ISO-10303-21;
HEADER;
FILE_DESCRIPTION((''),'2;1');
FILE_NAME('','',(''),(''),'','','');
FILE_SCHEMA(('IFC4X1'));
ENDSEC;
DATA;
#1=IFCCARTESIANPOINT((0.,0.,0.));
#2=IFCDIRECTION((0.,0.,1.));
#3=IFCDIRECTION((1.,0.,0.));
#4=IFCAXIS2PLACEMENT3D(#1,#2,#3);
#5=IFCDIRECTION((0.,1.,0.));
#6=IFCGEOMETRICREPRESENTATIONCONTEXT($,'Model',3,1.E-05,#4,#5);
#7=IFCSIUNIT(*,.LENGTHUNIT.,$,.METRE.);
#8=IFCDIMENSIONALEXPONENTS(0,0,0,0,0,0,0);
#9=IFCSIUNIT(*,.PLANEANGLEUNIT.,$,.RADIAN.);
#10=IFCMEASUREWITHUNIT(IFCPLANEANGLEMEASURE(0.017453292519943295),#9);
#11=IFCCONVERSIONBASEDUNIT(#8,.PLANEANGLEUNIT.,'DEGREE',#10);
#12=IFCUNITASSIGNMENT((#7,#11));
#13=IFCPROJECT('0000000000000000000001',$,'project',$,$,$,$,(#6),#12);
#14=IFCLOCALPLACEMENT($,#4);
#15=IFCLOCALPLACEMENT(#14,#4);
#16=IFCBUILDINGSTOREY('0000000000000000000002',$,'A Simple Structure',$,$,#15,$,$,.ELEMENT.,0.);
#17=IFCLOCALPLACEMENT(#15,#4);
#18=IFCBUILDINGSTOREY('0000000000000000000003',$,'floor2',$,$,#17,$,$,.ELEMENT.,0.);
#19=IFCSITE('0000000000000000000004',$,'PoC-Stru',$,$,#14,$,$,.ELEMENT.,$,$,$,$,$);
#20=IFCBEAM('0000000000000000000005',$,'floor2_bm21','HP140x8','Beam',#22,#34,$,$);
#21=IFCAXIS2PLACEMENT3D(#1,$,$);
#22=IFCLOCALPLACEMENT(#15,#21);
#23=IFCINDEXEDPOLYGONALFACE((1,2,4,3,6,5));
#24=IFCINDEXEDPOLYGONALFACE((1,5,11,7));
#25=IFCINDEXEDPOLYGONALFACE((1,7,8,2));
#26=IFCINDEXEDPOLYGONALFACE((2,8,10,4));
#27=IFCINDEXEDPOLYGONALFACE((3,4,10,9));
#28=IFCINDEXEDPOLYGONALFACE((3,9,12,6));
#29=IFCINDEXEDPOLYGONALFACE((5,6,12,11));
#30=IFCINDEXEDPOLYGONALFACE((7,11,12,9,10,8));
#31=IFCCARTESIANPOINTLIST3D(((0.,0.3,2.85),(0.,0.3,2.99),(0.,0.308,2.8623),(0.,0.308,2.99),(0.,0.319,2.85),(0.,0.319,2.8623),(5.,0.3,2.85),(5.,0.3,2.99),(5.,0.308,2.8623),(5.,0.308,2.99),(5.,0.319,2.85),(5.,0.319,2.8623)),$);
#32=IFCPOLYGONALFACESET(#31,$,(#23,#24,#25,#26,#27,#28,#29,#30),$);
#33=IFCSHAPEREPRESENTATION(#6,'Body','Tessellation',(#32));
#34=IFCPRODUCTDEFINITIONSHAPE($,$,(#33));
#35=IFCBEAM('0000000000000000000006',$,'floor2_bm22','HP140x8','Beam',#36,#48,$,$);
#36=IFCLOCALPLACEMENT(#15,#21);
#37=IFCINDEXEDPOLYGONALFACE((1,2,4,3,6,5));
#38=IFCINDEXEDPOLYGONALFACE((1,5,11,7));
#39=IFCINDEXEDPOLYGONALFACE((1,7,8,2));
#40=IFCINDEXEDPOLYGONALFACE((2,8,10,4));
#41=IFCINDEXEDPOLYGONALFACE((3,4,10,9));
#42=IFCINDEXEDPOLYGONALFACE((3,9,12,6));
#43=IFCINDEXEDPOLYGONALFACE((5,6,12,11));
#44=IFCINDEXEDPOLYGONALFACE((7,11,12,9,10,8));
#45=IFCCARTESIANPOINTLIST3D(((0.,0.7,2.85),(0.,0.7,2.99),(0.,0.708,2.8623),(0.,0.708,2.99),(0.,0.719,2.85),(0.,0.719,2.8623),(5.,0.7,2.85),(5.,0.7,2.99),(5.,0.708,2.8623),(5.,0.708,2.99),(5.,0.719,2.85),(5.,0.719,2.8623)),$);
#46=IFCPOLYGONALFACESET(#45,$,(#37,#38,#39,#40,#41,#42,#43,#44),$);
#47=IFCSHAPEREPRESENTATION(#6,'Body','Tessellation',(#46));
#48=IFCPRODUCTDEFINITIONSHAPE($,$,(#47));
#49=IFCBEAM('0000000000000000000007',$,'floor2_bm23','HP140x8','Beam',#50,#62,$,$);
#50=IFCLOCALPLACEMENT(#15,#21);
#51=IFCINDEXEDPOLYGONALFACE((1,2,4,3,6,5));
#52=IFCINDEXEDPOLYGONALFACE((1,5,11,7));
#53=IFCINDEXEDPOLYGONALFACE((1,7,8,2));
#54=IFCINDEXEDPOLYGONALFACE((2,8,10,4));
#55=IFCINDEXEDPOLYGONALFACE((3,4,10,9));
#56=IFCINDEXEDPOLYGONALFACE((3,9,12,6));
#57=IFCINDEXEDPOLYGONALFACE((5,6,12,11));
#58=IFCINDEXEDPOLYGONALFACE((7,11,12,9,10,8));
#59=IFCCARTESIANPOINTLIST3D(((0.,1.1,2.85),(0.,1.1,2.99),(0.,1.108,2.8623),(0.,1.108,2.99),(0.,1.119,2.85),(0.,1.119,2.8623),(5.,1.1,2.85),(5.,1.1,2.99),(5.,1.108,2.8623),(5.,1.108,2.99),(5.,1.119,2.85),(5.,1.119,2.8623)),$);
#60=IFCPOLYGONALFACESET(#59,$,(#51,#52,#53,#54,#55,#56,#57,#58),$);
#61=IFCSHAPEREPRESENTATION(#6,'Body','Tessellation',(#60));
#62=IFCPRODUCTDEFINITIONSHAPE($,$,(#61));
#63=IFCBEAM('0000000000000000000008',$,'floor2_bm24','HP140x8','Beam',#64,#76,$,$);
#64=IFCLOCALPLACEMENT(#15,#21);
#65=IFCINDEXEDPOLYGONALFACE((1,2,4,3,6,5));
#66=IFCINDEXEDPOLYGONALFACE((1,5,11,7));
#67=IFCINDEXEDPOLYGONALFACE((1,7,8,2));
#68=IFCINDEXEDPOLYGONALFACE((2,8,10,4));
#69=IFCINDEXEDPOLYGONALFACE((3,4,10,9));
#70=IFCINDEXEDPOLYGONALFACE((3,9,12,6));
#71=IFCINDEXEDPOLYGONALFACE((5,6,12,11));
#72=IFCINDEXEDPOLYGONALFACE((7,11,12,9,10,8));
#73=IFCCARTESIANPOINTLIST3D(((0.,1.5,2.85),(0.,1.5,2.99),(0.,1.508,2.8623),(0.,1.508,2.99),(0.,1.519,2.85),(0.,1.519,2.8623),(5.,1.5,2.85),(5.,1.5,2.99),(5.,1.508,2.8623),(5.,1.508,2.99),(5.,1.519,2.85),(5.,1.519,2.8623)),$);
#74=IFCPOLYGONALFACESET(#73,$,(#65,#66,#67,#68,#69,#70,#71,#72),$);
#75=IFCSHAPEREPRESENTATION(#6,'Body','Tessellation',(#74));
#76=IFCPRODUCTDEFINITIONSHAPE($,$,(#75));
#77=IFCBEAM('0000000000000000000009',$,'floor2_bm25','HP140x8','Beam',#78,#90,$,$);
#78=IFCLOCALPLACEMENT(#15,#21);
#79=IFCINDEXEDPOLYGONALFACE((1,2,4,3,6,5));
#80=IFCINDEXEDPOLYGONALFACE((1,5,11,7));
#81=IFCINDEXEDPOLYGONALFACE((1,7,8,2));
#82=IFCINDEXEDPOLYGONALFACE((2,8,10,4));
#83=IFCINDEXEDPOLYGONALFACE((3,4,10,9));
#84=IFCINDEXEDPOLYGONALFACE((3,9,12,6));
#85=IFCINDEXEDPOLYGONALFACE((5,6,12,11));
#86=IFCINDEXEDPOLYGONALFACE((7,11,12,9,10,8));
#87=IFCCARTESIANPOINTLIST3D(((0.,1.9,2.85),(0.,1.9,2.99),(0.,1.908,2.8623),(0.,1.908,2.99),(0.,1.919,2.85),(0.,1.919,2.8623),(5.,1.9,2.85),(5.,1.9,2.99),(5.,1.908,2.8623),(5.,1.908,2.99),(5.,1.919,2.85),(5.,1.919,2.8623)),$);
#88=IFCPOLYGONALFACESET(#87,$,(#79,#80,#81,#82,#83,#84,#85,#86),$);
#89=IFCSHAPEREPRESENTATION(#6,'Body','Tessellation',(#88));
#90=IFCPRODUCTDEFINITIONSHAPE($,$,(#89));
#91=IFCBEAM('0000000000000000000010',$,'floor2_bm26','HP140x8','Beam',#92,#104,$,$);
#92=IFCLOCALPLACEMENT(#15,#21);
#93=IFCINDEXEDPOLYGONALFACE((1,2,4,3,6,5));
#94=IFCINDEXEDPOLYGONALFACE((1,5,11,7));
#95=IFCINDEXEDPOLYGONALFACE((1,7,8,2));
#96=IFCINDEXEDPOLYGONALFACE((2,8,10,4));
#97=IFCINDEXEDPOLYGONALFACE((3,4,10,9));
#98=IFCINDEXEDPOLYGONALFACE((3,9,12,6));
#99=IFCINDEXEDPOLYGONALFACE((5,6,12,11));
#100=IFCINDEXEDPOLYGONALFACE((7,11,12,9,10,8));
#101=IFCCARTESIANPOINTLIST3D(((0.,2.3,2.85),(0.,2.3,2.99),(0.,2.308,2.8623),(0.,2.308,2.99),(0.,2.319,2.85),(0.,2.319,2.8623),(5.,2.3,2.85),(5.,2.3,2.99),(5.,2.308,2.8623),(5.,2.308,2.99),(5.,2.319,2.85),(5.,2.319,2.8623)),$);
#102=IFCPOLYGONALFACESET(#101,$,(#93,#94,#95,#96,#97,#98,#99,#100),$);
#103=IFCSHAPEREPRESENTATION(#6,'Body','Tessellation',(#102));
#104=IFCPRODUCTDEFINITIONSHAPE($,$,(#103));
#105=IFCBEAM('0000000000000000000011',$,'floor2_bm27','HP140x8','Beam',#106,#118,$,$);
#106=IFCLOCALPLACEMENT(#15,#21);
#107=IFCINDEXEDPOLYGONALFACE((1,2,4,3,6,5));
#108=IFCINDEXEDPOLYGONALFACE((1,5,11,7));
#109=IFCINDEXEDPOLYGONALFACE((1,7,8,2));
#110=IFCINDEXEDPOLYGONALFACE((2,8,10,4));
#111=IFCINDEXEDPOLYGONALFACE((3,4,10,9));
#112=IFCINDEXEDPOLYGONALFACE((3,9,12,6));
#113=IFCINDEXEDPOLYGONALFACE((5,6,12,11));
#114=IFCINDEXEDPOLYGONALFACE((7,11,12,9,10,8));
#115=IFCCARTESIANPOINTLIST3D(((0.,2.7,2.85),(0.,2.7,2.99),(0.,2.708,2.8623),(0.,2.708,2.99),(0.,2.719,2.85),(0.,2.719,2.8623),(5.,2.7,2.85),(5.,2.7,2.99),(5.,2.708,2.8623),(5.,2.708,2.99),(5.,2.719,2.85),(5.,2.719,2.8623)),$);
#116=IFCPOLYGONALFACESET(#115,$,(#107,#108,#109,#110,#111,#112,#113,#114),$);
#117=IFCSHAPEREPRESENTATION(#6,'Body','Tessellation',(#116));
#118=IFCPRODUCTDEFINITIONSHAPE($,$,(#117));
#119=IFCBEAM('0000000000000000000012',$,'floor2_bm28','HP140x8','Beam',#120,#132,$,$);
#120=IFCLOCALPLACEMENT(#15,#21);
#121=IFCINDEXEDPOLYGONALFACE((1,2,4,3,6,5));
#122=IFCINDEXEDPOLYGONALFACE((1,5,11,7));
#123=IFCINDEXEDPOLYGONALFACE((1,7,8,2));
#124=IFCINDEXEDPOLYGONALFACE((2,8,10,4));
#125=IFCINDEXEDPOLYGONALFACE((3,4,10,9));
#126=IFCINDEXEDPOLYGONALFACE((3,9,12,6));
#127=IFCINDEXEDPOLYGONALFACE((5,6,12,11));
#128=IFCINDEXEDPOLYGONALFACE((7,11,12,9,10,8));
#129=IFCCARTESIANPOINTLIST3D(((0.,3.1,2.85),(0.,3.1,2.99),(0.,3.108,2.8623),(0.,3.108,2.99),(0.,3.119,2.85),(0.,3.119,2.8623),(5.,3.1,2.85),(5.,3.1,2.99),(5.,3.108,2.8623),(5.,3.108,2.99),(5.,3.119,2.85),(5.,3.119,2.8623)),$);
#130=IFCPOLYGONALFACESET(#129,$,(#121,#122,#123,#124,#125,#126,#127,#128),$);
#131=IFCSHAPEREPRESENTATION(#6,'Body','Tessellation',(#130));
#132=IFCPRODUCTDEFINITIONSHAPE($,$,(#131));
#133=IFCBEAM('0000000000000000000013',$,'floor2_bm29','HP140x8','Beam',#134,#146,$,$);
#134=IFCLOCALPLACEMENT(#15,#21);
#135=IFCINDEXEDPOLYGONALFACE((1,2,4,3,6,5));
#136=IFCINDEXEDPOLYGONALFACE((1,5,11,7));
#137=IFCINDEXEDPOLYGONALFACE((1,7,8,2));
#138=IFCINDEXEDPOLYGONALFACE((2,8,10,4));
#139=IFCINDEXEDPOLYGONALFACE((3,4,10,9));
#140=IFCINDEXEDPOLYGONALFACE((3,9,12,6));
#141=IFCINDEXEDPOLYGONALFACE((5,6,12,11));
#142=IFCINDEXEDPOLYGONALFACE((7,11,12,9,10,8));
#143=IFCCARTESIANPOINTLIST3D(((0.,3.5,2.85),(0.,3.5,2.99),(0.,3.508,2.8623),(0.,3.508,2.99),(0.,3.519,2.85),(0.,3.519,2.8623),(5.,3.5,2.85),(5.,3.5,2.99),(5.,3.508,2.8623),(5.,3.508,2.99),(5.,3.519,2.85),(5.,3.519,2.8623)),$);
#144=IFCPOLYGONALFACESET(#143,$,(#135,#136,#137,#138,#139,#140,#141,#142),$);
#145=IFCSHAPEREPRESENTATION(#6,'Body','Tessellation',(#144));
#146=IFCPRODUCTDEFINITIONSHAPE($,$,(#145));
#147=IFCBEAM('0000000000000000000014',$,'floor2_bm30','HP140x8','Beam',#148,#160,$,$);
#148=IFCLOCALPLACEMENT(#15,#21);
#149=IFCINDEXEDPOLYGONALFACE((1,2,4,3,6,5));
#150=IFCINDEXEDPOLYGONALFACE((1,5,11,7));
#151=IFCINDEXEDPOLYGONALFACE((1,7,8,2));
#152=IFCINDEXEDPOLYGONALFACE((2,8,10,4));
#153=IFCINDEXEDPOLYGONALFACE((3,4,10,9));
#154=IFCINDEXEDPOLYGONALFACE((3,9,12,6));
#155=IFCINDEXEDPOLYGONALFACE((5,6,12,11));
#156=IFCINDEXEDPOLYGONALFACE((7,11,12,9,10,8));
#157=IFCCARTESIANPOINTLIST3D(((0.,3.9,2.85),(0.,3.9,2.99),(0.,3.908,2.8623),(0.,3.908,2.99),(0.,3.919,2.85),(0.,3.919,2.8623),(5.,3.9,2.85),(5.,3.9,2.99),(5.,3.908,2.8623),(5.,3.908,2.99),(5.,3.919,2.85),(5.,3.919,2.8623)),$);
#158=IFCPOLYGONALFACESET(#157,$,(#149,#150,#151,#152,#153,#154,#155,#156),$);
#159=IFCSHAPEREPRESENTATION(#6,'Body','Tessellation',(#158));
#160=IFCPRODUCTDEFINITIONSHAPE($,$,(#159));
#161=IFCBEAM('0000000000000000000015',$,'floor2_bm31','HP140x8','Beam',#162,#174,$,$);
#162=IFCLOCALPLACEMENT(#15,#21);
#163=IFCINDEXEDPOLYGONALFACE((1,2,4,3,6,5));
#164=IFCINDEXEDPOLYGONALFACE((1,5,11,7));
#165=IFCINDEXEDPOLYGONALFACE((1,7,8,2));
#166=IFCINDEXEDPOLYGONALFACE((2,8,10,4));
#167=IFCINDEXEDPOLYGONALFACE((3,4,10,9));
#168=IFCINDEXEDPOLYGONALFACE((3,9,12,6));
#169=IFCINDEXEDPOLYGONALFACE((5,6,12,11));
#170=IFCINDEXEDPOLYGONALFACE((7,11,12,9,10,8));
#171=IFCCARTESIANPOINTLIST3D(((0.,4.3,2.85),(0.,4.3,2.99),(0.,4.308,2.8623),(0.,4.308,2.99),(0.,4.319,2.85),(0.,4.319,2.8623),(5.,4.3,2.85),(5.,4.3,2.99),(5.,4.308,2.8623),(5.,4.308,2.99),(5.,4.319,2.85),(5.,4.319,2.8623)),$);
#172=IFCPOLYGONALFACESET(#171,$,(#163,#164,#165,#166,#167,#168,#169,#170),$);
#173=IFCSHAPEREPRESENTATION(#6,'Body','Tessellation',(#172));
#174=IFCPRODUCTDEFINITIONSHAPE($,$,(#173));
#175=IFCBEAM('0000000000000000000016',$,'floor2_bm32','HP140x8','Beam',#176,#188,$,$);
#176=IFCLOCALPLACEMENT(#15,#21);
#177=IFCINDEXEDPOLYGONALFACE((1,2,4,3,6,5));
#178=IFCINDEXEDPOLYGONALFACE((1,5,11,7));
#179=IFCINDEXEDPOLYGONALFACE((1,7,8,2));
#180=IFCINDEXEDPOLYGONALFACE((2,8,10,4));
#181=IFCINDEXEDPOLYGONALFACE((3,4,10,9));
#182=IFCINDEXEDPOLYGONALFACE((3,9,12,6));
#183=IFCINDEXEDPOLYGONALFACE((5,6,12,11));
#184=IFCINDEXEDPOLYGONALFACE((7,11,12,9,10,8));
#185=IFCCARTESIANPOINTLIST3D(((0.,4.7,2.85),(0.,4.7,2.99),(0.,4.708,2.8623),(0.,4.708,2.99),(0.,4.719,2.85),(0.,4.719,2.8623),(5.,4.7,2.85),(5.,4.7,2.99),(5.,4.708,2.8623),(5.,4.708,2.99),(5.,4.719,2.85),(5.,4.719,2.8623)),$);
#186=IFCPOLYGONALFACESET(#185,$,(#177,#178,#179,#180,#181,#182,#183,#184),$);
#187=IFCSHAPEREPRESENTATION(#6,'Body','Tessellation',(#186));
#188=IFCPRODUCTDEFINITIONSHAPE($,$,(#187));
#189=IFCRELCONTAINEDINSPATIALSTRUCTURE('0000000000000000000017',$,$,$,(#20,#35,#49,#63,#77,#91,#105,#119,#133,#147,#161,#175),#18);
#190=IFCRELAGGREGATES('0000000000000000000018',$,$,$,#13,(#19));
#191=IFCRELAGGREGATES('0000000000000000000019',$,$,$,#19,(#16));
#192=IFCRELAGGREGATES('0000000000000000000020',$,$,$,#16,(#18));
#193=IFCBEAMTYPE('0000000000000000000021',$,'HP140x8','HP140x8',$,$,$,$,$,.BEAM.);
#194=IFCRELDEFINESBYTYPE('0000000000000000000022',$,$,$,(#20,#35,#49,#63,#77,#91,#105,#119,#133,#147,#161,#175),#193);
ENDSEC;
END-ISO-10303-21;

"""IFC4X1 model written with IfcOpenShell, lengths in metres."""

from ifc_helpers import new_model, entity, si_unit, converted_unit, direction, frame, origin, origin_with_axes, place, context, project, spatial, polyline, outline, extrude, type_object, element, save


model = new_model("IFC4X1")

# Units and contexts
model_context = context("Model", 3, precision=1e-05, world=origin_with_axes(), true_north=direction((0.0, 1.0, 0.0)))
ifc_project = project(units=[si_unit("LENGTHUNIT", "METRE"), converted_unit("PLANEANGLEUNIT", "DEGREE", entity("IfcPlaneAngleMeasure", 0.017453292519943295), si_unit("PLANEANGLEUNIT", "RADIAN"), dimensions=[0, 0, 0, 0, 0, 0, 0])], contexts=[model_context])

# Site, storeys
site_placement = place(None, origin_with_axes())
site = spatial("IfcSite", under=ifc_project, at=site_placement, Name="PoC-Stru", CompositionType="ELEMENT")
storey_1_placement = place(site_placement, origin_with_axes())
storey_1 = spatial("IfcBuildingStorey", under=site, at=storey_1_placement, Name="A Simple Structure", CompositionType="ELEMENT", Elevation=0.0)
storey_2_placement = place(storey_1_placement, origin_with_axes())
storey_2 = spatial("IfcBuildingStorey", under=storey_1, at=storey_2_placement, Name="floor2", CompositionType="ELEMENT", Elevation=0.0)

# Beams
beam_type = type_object("IfcBeamType", Name="HP140x8", Description="HP140x8", PredefinedType="BEAM")
placement_1 = place(storey_2_placement, origin_with_axes())
beam_1_placement = place(placement_1, frame((0.0, 0.3, 2.99), z_axis=(1.0, 0.0, 0.0), x_axis=(0.0, 1.0, 0.0)))
element("IfcBeam", 1, at=beam_1_placement, inside=storey_2, type_object=beam_type, Name="floor2_bm21", Description="HP140x8", ObjectType="Beam", context=model_context, shape_type="SweptSolid", body=[
    extrude(outline(polyline([(0.0, 0.0), (0.008, 0.0), (0.008, -0.1277), (0.019, -0.1277), (0.019, -0.14), (0.0, -0.14)])), origin(), (0.0, 0.0, 1.0), 5.0),
])
placement_2 = place(storey_2_placement, origin_with_axes())
beam_2_placement = place(placement_2, frame((0.0, 0.7, 2.99), z_axis=(1.0, 0.0, 0.0), x_axis=(0.0, 1.0, 0.0)))
element("IfcBeam", 2, at=beam_2_placement, inside=storey_2, type_object=beam_type, Name="floor2_bm22", Description="HP140x8", ObjectType="Beam", context=model_context, shape_type="SweptSolid", body=[
    extrude(outline(polyline([(0.0, 0.0), (0.008, 0.0), (0.008, -0.1277), (0.019, -0.1277), (0.019, -0.14), (0.0, -0.14)])), origin(), (0.0, 0.0, 1.0), 5.0),
])
placement_3 = place(storey_2_placement, origin_with_axes())
beam_3_placement = place(placement_3, frame((0.0, 1.1, 2.99), z_axis=(1.0, 0.0, 0.0), x_axis=(0.0, 1.0, 0.0)))
element("IfcBeam", 3, at=beam_3_placement, inside=storey_2, type_object=beam_type, Name="floor2_bm23", Description="HP140x8", ObjectType="Beam", context=model_context, shape_type="SweptSolid", body=[
    extrude(outline(polyline([(0.0, 0.0), (0.008, 0.0), (0.008, -0.1277), (0.019, -0.1277), (0.019, -0.14), (0.0, -0.14)])), origin(), (0.0, 0.0, 1.0), 5.0),
])
placement_4 = place(storey_2_placement, origin_with_axes())
beam_4_placement = place(placement_4, frame((0.0, 1.5, 2.99), z_axis=(1.0, 0.0, 0.0), x_axis=(0.0, 1.0, 0.0)))
element("IfcBeam", 4, at=beam_4_placement, inside=storey_2, type_object=beam_type, Name="floor2_bm24", Description="HP140x8", ObjectType="Beam", context=model_context, shape_type="SweptSolid", body=[
    extrude(outline(polyline([(0.0, 0.0), (0.008, 0.0), (0.008, -0.1277), (0.019, -0.1277), (0.019, -0.14), (0.0, -0.14)])), origin(), (0.0, 0.0, 1.0), 5.0),
])
placement_5 = place(storey_2_placement, origin_with_axes())
beam_5_placement = place(placement_5, frame((0.0, 1.9, 2.99), z_axis=(1.0, 0.0, 0.0), x_axis=(0.0, 1.0, 0.0)))
element("IfcBeam", 5, at=beam_5_placement, inside=storey_2, type_object=beam_type, Name="floor2_bm25", Description="HP140x8", ObjectType="Beam", context=model_context, shape_type="SweptSolid", body=[
    extrude(outline(polyline([(0.0, 0.0), (0.008, 0.0), (0.008, -0.1277), (0.019, -0.1277), (0.019, -0.14), (0.0, -0.14)])), origin(), (0.0, 0.0, 1.0), 5.0),
])
placement_6 = place(storey_2_placement, origin_with_axes())
beam_6_placement = place(placement_6, frame((0.0, 2.3, 2.99), z_axis=(1.0, 0.0, 0.0), x_axis=(0.0, 1.0, 0.0)))
element("IfcBeam", 6, at=beam_6_placement, inside=storey_2, type_object=beam_type, Name="floor2_bm26", Description="HP140x8", ObjectType="Beam", context=model_context, shape_type="SweptSolid", body=[
    extrude(outline(polyline([(0.0, 0.0), (0.008, 0.0), (0.008, -0.1277), (0.019, -0.1277), (0.019, -0.14), (0.0, -0.14)])), origin(), (0.0, 0.0, 1.0), 5.0),
])
placement_7 = place(storey_2_placement, origin_with_axes())
beam_7_placement = place(placement_7, frame((0.0, 2.7, 2.99), z_axis=(1.0, 0.0, 0.0), x_axis=(0.0, 1.0, 0.0)))
element("IfcBeam", 7, at=beam_7_placement, inside=storey_2, type_object=beam_type, Name="floor2_bm27", Description="HP140x8", ObjectType="Beam", context=model_context, shape_type="SweptSolid", body=[
    extrude(outline(polyline([(0.0, 0.0), (0.008, 0.0), (0.008, -0.1277), (0.019, -0.1277), (0.019, -0.14), (0.0, -0.14)])), origin(), (0.0, 0.0, 1.0), 5.0),
])
placement_8 = place(storey_2_placement, origin_with_axes())
beam_8_placement = place(placement_8, frame((0.0, 3.1, 2.99), z_axis=(1.0, 0.0, 0.0), x_axis=(0.0, 1.0, 0.0)))
element("IfcBeam", 8, at=beam_8_placement, inside=storey_2, type_object=beam_type, Name="floor2_bm28", Description="HP140x8", ObjectType="Beam", context=model_context, shape_type="SweptSolid", body=[
    extrude(outline(polyline([(0.0, 0.0), (0.008, 0.0), (0.008, -0.1277), (0.019, -0.1277), (0.019, -0.14), (0.0, -0.14)])), origin(), (0.0, 0.0, 1.0), 5.0),
])
placement_9 = place(storey_2_placement, origin_with_axes())
beam_9_placement = place(placement_9, frame((0.0, 3.5, 2.99), z_axis=(1.0, 0.0, 0.0), x_axis=(0.0, 1.0, 0.0)))
element("IfcBeam", 9, at=beam_9_placement, inside=storey_2, type_object=beam_type, Name="floor2_bm29", Description="HP140x8", ObjectType="Beam", context=model_context, shape_type="SweptSolid", body=[
    extrude(outline(polyline([(0.0, 0.0), (0.008, 0.0), (0.008, -0.1277), (0.019, -0.1277), (0.019, -0.14), (0.0, -0.14)])), origin(), (0.0, 0.0, 1.0), 5.0),
])
placement_10 = place(storey_2_placement, origin_with_axes())
beam_10_placement = place(placement_10, frame((0.0, 3.9, 2.99), z_axis=(1.0, 0.0, 0.0), x_axis=(0.0, 1.0, 0.0)))
element("IfcBeam", 10, at=beam_10_placement, inside=storey_2, type_object=beam_type, Name="floor2_bm30", Description="HP140x8", ObjectType="Beam", context=model_context, shape_type="SweptSolid", body=[
    extrude(outline(polyline([(0.0, 0.0), (0.008, 0.0), (0.008, -0.1277), (0.019, -0.1277), (0.019, -0.14), (0.0, -0.14)])), origin(), (0.0, 0.0, 1.0), 5.0),
])
placement_11 = place(storey_2_placement, origin_with_axes())
beam_11_placement = place(placement_11, frame((0.0, 4.3, 2.99), z_axis=(1.0, 0.0, 0.0), x_axis=(0.0, 1.0, 0.0)))
element("IfcBeam", 11, at=beam_11_placement, inside=storey_2, type_object=beam_type, Name="floor2_bm31", Description="HP140x8", ObjectType="Beam", context=model_context, shape_type="SweptSolid", body=[
    extrude(outline(polyline([(0.0, 0.0), (0.008, 0.0), (0.008, -0.1277), (0.019, -0.1277), (0.019, -0.14), (0.0, -0.14)])), origin(), (0.0, 0.0, 1.0), 5.0),
])
placement_12 = place(storey_2_placement, origin_with_axes())
beam_12_placement = place(placement_12, frame((0.0, 4.7, 2.99), z_axis=(1.0, 0.0, 0.0), x_axis=(0.0, 1.0, 0.0)))
element("IfcBeam", 12, at=beam_12_placement, inside=storey_2, type_object=beam_type, Name="floor2_bm32", Description="HP140x8", ObjectType="Beam", context=model_context, shape_type="SweptSolid", body=[
    extrude(outline(polyline([(0.0, 0.0), (0.008, 0.0), (0.008, -0.1277), (0.019, -0.1277), (0.019, -0.14), (0.0, -0.14)])), origin(), (0.0, 0.0, 1.0), 5.0),
])

save(model, "model.ifc")
